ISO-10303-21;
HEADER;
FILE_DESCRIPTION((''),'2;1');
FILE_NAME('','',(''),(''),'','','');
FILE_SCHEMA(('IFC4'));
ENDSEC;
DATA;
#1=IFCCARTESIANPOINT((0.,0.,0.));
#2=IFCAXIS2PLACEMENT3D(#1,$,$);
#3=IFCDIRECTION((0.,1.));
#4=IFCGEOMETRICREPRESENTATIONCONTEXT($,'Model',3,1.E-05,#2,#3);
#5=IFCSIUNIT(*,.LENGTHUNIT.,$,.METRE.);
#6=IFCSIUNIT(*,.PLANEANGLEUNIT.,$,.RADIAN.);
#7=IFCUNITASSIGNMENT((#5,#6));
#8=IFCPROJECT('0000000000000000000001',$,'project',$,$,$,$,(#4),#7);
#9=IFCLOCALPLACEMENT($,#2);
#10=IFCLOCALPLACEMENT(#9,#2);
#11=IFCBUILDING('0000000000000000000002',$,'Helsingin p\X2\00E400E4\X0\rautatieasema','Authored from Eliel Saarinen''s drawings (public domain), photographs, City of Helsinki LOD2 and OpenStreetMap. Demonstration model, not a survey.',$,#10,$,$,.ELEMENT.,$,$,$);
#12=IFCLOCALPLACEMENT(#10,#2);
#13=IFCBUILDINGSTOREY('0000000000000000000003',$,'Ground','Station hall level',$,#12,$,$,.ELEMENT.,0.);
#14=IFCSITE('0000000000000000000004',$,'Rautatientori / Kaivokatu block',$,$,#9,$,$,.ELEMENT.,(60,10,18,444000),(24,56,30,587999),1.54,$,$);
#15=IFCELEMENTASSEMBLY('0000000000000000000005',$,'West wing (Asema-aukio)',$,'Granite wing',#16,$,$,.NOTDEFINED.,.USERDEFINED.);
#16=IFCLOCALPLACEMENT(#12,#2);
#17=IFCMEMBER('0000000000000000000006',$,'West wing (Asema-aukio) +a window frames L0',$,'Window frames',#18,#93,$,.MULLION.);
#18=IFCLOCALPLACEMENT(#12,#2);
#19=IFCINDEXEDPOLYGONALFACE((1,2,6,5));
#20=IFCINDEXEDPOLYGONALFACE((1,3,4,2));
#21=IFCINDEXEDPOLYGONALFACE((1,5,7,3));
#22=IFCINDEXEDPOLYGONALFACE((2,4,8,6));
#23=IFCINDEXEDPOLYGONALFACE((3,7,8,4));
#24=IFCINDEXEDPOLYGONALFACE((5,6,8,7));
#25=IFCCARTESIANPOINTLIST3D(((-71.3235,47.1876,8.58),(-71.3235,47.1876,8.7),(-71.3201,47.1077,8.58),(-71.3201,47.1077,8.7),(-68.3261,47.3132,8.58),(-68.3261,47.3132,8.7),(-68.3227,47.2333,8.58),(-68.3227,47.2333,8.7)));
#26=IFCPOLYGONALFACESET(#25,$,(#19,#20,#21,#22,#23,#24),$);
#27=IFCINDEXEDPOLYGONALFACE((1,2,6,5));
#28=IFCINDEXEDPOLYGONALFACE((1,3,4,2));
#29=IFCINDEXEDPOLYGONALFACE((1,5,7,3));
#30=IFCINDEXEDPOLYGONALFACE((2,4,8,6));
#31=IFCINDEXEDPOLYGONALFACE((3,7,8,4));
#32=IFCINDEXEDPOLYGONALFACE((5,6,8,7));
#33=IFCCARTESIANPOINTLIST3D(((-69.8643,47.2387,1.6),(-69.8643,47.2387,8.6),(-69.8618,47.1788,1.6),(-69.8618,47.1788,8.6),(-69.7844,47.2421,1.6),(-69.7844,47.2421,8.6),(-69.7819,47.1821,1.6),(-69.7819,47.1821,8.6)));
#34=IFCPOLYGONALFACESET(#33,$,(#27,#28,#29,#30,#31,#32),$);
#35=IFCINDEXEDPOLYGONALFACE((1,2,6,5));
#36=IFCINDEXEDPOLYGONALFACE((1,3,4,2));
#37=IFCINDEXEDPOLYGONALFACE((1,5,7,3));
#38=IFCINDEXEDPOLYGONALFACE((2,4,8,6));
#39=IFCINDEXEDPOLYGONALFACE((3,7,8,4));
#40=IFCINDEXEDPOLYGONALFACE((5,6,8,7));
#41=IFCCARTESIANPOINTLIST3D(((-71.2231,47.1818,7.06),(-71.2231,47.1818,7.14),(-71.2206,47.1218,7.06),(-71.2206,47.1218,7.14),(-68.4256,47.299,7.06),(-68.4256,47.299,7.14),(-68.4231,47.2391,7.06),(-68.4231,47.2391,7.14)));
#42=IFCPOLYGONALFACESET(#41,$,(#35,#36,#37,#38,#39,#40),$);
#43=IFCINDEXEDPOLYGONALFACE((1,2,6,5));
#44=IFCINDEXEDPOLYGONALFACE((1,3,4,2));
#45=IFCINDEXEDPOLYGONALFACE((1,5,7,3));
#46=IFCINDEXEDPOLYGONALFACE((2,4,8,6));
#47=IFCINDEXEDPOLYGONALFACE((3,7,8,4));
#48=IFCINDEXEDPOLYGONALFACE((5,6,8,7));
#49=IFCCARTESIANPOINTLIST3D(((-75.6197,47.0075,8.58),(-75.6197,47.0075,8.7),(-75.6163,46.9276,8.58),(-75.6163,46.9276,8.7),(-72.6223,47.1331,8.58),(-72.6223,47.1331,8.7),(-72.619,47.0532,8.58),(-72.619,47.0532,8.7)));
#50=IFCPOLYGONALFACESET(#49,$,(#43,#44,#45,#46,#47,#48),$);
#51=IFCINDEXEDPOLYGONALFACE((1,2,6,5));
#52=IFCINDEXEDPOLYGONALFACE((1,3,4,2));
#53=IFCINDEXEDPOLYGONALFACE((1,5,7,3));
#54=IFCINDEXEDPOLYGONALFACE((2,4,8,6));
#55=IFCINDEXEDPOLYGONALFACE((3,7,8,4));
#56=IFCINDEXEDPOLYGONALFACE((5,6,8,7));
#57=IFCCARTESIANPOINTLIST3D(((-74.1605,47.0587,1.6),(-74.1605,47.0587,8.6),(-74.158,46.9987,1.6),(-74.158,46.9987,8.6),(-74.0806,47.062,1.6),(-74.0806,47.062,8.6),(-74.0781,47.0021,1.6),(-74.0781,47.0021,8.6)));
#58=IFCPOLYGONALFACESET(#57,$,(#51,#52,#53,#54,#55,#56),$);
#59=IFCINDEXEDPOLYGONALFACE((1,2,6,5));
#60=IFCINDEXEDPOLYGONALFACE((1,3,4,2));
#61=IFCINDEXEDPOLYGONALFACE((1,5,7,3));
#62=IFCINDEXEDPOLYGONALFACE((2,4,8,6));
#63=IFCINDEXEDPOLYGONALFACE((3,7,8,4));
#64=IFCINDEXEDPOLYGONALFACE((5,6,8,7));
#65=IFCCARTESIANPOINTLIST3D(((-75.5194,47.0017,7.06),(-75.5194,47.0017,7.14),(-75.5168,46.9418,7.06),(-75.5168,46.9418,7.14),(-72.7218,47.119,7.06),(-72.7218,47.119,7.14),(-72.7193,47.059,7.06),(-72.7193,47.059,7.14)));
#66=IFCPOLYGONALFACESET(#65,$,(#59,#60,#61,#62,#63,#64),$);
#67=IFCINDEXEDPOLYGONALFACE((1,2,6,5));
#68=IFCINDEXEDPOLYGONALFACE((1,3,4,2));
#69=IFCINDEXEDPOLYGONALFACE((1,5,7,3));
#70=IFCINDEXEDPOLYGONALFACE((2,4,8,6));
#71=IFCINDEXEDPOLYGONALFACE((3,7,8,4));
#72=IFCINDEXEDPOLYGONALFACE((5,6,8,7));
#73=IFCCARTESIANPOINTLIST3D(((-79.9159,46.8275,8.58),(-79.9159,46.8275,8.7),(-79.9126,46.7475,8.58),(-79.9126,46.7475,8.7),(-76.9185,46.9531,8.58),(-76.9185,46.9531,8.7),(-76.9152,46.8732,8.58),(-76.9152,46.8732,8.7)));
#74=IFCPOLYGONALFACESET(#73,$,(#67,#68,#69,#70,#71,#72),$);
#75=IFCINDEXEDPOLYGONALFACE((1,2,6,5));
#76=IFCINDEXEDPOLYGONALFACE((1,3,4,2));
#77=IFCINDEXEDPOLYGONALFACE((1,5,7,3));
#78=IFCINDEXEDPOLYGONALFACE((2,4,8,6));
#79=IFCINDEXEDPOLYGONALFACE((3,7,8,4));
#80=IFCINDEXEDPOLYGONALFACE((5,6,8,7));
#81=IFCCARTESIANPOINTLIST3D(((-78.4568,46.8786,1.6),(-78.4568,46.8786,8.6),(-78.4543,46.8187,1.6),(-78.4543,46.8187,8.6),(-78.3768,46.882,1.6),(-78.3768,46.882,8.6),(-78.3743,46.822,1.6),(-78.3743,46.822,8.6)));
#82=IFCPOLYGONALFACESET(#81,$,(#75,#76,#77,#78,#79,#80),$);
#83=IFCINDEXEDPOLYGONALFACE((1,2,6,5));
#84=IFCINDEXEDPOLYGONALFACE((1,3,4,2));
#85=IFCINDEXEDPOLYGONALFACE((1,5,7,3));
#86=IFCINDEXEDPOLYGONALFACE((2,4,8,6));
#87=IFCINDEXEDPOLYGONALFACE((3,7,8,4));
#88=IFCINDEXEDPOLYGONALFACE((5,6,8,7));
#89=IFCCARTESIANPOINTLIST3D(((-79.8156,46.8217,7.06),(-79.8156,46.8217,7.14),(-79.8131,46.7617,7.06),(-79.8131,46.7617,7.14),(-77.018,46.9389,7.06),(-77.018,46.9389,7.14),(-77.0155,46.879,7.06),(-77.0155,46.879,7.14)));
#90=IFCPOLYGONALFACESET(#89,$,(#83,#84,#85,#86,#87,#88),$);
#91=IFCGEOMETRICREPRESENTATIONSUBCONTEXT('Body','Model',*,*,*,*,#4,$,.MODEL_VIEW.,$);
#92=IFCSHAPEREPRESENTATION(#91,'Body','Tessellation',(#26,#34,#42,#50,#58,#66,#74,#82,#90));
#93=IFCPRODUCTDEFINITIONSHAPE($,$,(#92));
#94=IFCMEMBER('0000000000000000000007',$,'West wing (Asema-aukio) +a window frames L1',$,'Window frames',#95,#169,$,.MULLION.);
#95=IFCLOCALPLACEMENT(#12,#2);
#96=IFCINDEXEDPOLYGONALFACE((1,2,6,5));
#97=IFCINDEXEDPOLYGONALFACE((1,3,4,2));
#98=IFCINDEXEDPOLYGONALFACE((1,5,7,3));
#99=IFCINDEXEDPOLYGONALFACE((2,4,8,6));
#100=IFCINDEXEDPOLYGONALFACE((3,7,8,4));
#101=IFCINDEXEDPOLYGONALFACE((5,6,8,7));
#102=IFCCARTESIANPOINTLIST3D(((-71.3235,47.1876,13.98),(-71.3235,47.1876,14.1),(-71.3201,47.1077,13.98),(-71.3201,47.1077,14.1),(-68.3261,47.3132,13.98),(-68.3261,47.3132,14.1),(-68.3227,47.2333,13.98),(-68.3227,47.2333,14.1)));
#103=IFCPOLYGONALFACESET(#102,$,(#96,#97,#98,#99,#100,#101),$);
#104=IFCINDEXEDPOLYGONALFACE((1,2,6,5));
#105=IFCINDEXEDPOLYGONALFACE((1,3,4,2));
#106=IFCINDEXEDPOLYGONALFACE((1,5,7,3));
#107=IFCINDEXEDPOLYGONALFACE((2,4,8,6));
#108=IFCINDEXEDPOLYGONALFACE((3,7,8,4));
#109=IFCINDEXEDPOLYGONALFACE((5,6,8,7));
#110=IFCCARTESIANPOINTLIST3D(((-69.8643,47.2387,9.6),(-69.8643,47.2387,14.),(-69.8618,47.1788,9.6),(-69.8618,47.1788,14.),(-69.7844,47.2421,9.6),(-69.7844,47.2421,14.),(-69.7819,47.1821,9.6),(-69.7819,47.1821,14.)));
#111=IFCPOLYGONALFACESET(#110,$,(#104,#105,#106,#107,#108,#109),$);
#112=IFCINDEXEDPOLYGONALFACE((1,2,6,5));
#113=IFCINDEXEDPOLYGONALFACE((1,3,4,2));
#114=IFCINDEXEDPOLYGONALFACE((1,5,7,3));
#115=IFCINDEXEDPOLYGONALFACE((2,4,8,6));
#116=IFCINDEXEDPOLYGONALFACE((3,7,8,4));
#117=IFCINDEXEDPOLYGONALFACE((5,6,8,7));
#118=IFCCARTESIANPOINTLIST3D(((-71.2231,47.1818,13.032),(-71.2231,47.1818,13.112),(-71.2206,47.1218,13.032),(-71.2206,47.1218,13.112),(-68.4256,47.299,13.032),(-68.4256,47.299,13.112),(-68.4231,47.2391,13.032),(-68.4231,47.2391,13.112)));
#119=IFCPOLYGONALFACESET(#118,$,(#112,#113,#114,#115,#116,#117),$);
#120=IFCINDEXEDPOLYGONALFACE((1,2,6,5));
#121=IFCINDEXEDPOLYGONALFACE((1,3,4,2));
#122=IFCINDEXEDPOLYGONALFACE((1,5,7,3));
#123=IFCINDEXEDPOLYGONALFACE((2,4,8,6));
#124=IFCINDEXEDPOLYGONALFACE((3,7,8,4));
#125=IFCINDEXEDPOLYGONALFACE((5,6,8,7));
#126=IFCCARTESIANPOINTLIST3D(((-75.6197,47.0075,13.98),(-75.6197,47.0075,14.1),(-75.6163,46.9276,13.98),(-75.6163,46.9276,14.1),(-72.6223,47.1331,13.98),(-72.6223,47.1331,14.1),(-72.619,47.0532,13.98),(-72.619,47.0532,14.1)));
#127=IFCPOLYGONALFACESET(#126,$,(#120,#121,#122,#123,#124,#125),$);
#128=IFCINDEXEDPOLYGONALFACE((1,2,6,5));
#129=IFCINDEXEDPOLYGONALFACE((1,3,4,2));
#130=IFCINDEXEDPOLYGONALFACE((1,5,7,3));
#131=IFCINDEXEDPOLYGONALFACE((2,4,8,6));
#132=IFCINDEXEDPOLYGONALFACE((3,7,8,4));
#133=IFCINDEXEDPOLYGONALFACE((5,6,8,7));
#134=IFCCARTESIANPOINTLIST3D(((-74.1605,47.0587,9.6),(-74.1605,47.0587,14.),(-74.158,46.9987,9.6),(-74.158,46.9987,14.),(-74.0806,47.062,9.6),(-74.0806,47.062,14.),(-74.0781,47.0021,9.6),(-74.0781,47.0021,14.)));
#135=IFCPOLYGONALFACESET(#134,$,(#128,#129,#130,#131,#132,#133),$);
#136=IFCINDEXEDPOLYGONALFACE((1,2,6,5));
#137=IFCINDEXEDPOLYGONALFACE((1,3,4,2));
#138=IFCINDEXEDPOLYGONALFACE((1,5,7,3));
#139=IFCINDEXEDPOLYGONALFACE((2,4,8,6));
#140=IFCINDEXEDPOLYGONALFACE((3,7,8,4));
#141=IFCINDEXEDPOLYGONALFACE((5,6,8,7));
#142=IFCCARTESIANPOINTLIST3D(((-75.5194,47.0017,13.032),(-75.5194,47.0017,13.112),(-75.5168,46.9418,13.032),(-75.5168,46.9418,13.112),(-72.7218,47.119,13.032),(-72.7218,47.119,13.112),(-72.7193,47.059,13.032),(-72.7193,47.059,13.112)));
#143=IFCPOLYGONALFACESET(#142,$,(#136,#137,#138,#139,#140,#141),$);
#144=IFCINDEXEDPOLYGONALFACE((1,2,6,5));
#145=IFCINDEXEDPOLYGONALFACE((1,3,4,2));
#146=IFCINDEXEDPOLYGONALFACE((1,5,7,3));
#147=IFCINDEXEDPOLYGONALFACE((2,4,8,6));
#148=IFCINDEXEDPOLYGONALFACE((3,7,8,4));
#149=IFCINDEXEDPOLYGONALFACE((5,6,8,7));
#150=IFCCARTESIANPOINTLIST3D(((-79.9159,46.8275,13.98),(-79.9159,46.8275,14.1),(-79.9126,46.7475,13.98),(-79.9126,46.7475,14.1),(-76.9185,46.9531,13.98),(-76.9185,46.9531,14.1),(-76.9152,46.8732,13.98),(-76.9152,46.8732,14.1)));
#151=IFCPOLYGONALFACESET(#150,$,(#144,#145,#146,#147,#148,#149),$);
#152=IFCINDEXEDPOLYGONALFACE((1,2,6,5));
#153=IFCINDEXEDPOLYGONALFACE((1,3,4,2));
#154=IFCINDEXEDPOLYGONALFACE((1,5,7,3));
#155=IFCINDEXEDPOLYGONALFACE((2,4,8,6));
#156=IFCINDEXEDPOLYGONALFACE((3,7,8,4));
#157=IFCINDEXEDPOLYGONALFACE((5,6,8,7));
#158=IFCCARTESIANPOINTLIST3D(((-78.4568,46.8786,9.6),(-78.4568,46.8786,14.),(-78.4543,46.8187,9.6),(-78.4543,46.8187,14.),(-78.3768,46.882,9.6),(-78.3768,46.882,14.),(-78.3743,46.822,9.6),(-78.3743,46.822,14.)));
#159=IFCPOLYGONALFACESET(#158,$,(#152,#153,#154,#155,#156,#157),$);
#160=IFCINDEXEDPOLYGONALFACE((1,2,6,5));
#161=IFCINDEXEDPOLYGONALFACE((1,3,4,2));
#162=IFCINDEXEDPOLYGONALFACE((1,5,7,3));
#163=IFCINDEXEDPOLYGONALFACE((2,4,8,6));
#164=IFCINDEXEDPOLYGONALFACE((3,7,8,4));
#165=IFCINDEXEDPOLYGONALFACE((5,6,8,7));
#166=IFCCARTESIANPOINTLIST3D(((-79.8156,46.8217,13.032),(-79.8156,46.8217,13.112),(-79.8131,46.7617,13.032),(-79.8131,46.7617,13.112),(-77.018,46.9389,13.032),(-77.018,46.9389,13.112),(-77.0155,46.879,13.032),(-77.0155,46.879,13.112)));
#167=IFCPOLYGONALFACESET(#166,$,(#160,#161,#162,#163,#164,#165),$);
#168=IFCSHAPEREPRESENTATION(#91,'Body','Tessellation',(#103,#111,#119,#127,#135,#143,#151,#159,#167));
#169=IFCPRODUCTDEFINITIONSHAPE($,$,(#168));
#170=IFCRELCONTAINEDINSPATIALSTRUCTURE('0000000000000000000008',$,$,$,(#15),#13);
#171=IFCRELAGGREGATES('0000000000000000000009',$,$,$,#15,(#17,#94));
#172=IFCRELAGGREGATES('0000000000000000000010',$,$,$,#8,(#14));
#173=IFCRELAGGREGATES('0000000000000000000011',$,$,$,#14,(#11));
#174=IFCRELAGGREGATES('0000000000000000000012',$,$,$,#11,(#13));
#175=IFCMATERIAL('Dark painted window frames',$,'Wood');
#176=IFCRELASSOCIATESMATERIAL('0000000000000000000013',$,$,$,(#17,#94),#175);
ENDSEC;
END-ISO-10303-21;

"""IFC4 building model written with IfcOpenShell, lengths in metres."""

from ifc_helpers import new_model, si_unit, direction, frame, frame_2d, origin, place, context, subcontext, project, spatial, rectangle, extrude, material, element, aggregate, save


model = new_model("IFC4")

# Units and contexts
model_context = context("Model", 3, precision=1e-05, world=origin(), true_north=direction((0.0, 1.0)))
body_context = subcontext(model_context, "Body", "Model", "MODEL_VIEW")
ifc_project = project(units=[si_unit("LENGTHUNIT", "METRE"), si_unit("PLANEANGLEUNIT", "RADIAN")], contexts=[model_context])

# Site, building, storey
site_placement = place(None, origin())
site = spatial("IfcSite", under=ifc_project, at=site_placement, Name="Rautatientori / Kaivokatu block", CompositionType="ELEMENT", RefLatitude=(60, 10, 18, 444000), RefLongitude=(24, 56, 30, 587999), RefElevation=1.54)
building_placement = place(site_placement, origin())
building = spatial("IfcBuilding", under=site, at=building_placement, Name="Helsingin päärautatieasema", Description="Authored from Eliel Saarinen's drawings (public domain), photographs, City of Helsinki LOD2 and OpenStreetMap. Demonstration model, not a survey.", CompositionType="ELEMENT")
storey_placement = place(building_placement, origin())
storey = spatial("IfcBuildingStorey", under=building, at=storey_placement, Name="Ground", Description="Station hall level", CompositionType="ELEMENT", Elevation=0.0)

# Element assembly, members
assembly_placement = place(building_placement, origin())
assembly = element("IfcElementAssembly", 1, at=assembly_placement, inside=storey, Name="West wing (Asema-aukio)", ObjectType="Granite wing", AssemblyPlace="NOTDEFINED", PredefinedType="USERDEFINED")
ifc_material_1 = material(Name="Dark painted window frames", Category="Wood")
member_1_placement = place(building_placement, origin())
member_1 = element("IfcMember", 2, at=member_1_placement, material=ifc_material_1, Name="West wing (Asema-aukio) +a window frames L0", ObjectType="Window frames", PredefinedType="MULLION", context=body_context, shape_type="SweptSolid", body=[
    extrude(rectangle(XDim=3.0, YDim=0.08, at=frame_2d((0.0, 0.0), x_axis=(-0.999123, -0.041876))), frame((-69.8231, 47.2104, 8.58)), (0.0, 0.0, 1.0), 0.12),
    extrude(rectangle(XDim=0.08, YDim=0.06, at=frame_2d((0.0, 0.0), x_axis=(-0.999123, -0.041876))), frame((-69.8231, 47.2104, 1.6)), (0.0, 0.0, 1.0), 7.0),
    extrude(rectangle(XDim=2.8, YDim=0.06, at=frame_2d((0.0, 0.0), x_axis=(-0.999123, -0.041876))), frame((-69.8231, 47.2104, 7.06)), (0.0, 0.0, 1.0), 0.08),
    extrude(rectangle(XDim=3.0, YDim=0.08, at=frame_2d((0.0, 0.0), x_axis=(-0.999123, -0.041876))), frame((-74.1193, 47.0304, 8.58)), (0.0, 0.0, 1.0), 0.12),
    extrude(rectangle(XDim=0.08, YDim=0.06, at=frame_2d((0.0, 0.0), x_axis=(-0.999123, -0.041876))), frame((-74.1193, 47.0304, 1.6)), (0.0, 0.0, 1.0), 7.0),
    extrude(rectangle(XDim=2.8, YDim=0.06, at=frame_2d((0.0, 0.0), x_axis=(-0.999123, -0.041876))), frame((-74.1193, 47.0304, 7.06)), (0.0, 0.0, 1.0), 0.08),
    extrude(rectangle(XDim=3.0, YDim=0.08, at=frame_2d((0.0, 0.0), x_axis=(-0.999123, -0.041876))), frame((-78.4156, 46.8503, 8.58)), (0.0, 0.0, 1.0), 0.12),
    extrude(rectangle(XDim=0.08, YDim=0.06, at=frame_2d((0.0, 0.0), x_axis=(-0.999123, -0.041876))), frame((-78.4156, 46.8503, 1.6)), (0.0, 0.0, 1.0), 7.0),
    extrude(rectangle(XDim=2.8, YDim=0.06, at=frame_2d((0.0, 0.0), x_axis=(-0.999123, -0.041876))), frame((-78.4156, 46.8503, 7.06)), (0.0, 0.0, 1.0), 0.08),
])
member_2_placement = place(building_placement, origin())
member_2 = element("IfcMember", 3, at=member_2_placement, material=ifc_material_1, Name="West wing (Asema-aukio) +a window frames L1", ObjectType="Window frames", PredefinedType="MULLION", context=body_context, shape_type="SweptSolid", body=[
    extrude(rectangle(XDim=3.0, YDim=0.08, at=frame_2d((0.0, 0.0), x_axis=(-0.999123, -0.041876))), frame((-69.8231, 47.2104, 13.98)), (0.0, 0.0, 1.0), 0.12),
    extrude(rectangle(XDim=0.08, YDim=0.06, at=frame_2d((0.0, 0.0), x_axis=(-0.999123, -0.041876))), frame((-69.8231, 47.2104, 9.6)), (0.0, 0.0, 1.0), 4.4),
    extrude(rectangle(XDim=2.8, YDim=0.06, at=frame_2d((0.0, 0.0), x_axis=(-0.999123, -0.041876))), frame((-69.8231, 47.2104, 13.032)), (0.0, 0.0, 1.0), 0.08),
    extrude(rectangle(XDim=3.0, YDim=0.08, at=frame_2d((0.0, 0.0), x_axis=(-0.999123, -0.041876))), frame((-74.1193, 47.0304, 13.98)), (0.0, 0.0, 1.0), 0.12),
    extrude(rectangle(XDim=0.08, YDim=0.06, at=frame_2d((0.0, 0.0), x_axis=(-0.999123, -0.041876))), frame((-74.1193, 47.0304, 9.6)), (0.0, 0.0, 1.0), 4.4),
    extrude(rectangle(XDim=2.8, YDim=0.06, at=frame_2d((0.0, 0.0), x_axis=(-0.999123, -0.041876))), frame((-74.1193, 47.0304, 13.032)), (0.0, 0.0, 1.0), 0.08),
    extrude(rectangle(XDim=3.0, YDim=0.08, at=frame_2d((0.0, 0.0), x_axis=(-0.999123, -0.041876))), frame((-78.4156, 46.8503, 13.98)), (0.0, 0.0, 1.0), 0.12),
    extrude(rectangle(XDim=0.08, YDim=0.06, at=frame_2d((0.0, 0.0), x_axis=(-0.999123, -0.041876))), frame((-78.4156, 46.8503, 9.6)), (0.0, 0.0, 1.0), 4.4),
    extrude(rectangle(XDim=2.8, YDim=0.06, at=frame_2d((0.0, 0.0), x_axis=(-0.999123, -0.041876))), frame((-78.4156, 46.8503, 13.032)), (0.0, 0.0, 1.0), 0.08),
])
aggregate(assembly, [member_1, member_2])

save(model, "model.ifc")
